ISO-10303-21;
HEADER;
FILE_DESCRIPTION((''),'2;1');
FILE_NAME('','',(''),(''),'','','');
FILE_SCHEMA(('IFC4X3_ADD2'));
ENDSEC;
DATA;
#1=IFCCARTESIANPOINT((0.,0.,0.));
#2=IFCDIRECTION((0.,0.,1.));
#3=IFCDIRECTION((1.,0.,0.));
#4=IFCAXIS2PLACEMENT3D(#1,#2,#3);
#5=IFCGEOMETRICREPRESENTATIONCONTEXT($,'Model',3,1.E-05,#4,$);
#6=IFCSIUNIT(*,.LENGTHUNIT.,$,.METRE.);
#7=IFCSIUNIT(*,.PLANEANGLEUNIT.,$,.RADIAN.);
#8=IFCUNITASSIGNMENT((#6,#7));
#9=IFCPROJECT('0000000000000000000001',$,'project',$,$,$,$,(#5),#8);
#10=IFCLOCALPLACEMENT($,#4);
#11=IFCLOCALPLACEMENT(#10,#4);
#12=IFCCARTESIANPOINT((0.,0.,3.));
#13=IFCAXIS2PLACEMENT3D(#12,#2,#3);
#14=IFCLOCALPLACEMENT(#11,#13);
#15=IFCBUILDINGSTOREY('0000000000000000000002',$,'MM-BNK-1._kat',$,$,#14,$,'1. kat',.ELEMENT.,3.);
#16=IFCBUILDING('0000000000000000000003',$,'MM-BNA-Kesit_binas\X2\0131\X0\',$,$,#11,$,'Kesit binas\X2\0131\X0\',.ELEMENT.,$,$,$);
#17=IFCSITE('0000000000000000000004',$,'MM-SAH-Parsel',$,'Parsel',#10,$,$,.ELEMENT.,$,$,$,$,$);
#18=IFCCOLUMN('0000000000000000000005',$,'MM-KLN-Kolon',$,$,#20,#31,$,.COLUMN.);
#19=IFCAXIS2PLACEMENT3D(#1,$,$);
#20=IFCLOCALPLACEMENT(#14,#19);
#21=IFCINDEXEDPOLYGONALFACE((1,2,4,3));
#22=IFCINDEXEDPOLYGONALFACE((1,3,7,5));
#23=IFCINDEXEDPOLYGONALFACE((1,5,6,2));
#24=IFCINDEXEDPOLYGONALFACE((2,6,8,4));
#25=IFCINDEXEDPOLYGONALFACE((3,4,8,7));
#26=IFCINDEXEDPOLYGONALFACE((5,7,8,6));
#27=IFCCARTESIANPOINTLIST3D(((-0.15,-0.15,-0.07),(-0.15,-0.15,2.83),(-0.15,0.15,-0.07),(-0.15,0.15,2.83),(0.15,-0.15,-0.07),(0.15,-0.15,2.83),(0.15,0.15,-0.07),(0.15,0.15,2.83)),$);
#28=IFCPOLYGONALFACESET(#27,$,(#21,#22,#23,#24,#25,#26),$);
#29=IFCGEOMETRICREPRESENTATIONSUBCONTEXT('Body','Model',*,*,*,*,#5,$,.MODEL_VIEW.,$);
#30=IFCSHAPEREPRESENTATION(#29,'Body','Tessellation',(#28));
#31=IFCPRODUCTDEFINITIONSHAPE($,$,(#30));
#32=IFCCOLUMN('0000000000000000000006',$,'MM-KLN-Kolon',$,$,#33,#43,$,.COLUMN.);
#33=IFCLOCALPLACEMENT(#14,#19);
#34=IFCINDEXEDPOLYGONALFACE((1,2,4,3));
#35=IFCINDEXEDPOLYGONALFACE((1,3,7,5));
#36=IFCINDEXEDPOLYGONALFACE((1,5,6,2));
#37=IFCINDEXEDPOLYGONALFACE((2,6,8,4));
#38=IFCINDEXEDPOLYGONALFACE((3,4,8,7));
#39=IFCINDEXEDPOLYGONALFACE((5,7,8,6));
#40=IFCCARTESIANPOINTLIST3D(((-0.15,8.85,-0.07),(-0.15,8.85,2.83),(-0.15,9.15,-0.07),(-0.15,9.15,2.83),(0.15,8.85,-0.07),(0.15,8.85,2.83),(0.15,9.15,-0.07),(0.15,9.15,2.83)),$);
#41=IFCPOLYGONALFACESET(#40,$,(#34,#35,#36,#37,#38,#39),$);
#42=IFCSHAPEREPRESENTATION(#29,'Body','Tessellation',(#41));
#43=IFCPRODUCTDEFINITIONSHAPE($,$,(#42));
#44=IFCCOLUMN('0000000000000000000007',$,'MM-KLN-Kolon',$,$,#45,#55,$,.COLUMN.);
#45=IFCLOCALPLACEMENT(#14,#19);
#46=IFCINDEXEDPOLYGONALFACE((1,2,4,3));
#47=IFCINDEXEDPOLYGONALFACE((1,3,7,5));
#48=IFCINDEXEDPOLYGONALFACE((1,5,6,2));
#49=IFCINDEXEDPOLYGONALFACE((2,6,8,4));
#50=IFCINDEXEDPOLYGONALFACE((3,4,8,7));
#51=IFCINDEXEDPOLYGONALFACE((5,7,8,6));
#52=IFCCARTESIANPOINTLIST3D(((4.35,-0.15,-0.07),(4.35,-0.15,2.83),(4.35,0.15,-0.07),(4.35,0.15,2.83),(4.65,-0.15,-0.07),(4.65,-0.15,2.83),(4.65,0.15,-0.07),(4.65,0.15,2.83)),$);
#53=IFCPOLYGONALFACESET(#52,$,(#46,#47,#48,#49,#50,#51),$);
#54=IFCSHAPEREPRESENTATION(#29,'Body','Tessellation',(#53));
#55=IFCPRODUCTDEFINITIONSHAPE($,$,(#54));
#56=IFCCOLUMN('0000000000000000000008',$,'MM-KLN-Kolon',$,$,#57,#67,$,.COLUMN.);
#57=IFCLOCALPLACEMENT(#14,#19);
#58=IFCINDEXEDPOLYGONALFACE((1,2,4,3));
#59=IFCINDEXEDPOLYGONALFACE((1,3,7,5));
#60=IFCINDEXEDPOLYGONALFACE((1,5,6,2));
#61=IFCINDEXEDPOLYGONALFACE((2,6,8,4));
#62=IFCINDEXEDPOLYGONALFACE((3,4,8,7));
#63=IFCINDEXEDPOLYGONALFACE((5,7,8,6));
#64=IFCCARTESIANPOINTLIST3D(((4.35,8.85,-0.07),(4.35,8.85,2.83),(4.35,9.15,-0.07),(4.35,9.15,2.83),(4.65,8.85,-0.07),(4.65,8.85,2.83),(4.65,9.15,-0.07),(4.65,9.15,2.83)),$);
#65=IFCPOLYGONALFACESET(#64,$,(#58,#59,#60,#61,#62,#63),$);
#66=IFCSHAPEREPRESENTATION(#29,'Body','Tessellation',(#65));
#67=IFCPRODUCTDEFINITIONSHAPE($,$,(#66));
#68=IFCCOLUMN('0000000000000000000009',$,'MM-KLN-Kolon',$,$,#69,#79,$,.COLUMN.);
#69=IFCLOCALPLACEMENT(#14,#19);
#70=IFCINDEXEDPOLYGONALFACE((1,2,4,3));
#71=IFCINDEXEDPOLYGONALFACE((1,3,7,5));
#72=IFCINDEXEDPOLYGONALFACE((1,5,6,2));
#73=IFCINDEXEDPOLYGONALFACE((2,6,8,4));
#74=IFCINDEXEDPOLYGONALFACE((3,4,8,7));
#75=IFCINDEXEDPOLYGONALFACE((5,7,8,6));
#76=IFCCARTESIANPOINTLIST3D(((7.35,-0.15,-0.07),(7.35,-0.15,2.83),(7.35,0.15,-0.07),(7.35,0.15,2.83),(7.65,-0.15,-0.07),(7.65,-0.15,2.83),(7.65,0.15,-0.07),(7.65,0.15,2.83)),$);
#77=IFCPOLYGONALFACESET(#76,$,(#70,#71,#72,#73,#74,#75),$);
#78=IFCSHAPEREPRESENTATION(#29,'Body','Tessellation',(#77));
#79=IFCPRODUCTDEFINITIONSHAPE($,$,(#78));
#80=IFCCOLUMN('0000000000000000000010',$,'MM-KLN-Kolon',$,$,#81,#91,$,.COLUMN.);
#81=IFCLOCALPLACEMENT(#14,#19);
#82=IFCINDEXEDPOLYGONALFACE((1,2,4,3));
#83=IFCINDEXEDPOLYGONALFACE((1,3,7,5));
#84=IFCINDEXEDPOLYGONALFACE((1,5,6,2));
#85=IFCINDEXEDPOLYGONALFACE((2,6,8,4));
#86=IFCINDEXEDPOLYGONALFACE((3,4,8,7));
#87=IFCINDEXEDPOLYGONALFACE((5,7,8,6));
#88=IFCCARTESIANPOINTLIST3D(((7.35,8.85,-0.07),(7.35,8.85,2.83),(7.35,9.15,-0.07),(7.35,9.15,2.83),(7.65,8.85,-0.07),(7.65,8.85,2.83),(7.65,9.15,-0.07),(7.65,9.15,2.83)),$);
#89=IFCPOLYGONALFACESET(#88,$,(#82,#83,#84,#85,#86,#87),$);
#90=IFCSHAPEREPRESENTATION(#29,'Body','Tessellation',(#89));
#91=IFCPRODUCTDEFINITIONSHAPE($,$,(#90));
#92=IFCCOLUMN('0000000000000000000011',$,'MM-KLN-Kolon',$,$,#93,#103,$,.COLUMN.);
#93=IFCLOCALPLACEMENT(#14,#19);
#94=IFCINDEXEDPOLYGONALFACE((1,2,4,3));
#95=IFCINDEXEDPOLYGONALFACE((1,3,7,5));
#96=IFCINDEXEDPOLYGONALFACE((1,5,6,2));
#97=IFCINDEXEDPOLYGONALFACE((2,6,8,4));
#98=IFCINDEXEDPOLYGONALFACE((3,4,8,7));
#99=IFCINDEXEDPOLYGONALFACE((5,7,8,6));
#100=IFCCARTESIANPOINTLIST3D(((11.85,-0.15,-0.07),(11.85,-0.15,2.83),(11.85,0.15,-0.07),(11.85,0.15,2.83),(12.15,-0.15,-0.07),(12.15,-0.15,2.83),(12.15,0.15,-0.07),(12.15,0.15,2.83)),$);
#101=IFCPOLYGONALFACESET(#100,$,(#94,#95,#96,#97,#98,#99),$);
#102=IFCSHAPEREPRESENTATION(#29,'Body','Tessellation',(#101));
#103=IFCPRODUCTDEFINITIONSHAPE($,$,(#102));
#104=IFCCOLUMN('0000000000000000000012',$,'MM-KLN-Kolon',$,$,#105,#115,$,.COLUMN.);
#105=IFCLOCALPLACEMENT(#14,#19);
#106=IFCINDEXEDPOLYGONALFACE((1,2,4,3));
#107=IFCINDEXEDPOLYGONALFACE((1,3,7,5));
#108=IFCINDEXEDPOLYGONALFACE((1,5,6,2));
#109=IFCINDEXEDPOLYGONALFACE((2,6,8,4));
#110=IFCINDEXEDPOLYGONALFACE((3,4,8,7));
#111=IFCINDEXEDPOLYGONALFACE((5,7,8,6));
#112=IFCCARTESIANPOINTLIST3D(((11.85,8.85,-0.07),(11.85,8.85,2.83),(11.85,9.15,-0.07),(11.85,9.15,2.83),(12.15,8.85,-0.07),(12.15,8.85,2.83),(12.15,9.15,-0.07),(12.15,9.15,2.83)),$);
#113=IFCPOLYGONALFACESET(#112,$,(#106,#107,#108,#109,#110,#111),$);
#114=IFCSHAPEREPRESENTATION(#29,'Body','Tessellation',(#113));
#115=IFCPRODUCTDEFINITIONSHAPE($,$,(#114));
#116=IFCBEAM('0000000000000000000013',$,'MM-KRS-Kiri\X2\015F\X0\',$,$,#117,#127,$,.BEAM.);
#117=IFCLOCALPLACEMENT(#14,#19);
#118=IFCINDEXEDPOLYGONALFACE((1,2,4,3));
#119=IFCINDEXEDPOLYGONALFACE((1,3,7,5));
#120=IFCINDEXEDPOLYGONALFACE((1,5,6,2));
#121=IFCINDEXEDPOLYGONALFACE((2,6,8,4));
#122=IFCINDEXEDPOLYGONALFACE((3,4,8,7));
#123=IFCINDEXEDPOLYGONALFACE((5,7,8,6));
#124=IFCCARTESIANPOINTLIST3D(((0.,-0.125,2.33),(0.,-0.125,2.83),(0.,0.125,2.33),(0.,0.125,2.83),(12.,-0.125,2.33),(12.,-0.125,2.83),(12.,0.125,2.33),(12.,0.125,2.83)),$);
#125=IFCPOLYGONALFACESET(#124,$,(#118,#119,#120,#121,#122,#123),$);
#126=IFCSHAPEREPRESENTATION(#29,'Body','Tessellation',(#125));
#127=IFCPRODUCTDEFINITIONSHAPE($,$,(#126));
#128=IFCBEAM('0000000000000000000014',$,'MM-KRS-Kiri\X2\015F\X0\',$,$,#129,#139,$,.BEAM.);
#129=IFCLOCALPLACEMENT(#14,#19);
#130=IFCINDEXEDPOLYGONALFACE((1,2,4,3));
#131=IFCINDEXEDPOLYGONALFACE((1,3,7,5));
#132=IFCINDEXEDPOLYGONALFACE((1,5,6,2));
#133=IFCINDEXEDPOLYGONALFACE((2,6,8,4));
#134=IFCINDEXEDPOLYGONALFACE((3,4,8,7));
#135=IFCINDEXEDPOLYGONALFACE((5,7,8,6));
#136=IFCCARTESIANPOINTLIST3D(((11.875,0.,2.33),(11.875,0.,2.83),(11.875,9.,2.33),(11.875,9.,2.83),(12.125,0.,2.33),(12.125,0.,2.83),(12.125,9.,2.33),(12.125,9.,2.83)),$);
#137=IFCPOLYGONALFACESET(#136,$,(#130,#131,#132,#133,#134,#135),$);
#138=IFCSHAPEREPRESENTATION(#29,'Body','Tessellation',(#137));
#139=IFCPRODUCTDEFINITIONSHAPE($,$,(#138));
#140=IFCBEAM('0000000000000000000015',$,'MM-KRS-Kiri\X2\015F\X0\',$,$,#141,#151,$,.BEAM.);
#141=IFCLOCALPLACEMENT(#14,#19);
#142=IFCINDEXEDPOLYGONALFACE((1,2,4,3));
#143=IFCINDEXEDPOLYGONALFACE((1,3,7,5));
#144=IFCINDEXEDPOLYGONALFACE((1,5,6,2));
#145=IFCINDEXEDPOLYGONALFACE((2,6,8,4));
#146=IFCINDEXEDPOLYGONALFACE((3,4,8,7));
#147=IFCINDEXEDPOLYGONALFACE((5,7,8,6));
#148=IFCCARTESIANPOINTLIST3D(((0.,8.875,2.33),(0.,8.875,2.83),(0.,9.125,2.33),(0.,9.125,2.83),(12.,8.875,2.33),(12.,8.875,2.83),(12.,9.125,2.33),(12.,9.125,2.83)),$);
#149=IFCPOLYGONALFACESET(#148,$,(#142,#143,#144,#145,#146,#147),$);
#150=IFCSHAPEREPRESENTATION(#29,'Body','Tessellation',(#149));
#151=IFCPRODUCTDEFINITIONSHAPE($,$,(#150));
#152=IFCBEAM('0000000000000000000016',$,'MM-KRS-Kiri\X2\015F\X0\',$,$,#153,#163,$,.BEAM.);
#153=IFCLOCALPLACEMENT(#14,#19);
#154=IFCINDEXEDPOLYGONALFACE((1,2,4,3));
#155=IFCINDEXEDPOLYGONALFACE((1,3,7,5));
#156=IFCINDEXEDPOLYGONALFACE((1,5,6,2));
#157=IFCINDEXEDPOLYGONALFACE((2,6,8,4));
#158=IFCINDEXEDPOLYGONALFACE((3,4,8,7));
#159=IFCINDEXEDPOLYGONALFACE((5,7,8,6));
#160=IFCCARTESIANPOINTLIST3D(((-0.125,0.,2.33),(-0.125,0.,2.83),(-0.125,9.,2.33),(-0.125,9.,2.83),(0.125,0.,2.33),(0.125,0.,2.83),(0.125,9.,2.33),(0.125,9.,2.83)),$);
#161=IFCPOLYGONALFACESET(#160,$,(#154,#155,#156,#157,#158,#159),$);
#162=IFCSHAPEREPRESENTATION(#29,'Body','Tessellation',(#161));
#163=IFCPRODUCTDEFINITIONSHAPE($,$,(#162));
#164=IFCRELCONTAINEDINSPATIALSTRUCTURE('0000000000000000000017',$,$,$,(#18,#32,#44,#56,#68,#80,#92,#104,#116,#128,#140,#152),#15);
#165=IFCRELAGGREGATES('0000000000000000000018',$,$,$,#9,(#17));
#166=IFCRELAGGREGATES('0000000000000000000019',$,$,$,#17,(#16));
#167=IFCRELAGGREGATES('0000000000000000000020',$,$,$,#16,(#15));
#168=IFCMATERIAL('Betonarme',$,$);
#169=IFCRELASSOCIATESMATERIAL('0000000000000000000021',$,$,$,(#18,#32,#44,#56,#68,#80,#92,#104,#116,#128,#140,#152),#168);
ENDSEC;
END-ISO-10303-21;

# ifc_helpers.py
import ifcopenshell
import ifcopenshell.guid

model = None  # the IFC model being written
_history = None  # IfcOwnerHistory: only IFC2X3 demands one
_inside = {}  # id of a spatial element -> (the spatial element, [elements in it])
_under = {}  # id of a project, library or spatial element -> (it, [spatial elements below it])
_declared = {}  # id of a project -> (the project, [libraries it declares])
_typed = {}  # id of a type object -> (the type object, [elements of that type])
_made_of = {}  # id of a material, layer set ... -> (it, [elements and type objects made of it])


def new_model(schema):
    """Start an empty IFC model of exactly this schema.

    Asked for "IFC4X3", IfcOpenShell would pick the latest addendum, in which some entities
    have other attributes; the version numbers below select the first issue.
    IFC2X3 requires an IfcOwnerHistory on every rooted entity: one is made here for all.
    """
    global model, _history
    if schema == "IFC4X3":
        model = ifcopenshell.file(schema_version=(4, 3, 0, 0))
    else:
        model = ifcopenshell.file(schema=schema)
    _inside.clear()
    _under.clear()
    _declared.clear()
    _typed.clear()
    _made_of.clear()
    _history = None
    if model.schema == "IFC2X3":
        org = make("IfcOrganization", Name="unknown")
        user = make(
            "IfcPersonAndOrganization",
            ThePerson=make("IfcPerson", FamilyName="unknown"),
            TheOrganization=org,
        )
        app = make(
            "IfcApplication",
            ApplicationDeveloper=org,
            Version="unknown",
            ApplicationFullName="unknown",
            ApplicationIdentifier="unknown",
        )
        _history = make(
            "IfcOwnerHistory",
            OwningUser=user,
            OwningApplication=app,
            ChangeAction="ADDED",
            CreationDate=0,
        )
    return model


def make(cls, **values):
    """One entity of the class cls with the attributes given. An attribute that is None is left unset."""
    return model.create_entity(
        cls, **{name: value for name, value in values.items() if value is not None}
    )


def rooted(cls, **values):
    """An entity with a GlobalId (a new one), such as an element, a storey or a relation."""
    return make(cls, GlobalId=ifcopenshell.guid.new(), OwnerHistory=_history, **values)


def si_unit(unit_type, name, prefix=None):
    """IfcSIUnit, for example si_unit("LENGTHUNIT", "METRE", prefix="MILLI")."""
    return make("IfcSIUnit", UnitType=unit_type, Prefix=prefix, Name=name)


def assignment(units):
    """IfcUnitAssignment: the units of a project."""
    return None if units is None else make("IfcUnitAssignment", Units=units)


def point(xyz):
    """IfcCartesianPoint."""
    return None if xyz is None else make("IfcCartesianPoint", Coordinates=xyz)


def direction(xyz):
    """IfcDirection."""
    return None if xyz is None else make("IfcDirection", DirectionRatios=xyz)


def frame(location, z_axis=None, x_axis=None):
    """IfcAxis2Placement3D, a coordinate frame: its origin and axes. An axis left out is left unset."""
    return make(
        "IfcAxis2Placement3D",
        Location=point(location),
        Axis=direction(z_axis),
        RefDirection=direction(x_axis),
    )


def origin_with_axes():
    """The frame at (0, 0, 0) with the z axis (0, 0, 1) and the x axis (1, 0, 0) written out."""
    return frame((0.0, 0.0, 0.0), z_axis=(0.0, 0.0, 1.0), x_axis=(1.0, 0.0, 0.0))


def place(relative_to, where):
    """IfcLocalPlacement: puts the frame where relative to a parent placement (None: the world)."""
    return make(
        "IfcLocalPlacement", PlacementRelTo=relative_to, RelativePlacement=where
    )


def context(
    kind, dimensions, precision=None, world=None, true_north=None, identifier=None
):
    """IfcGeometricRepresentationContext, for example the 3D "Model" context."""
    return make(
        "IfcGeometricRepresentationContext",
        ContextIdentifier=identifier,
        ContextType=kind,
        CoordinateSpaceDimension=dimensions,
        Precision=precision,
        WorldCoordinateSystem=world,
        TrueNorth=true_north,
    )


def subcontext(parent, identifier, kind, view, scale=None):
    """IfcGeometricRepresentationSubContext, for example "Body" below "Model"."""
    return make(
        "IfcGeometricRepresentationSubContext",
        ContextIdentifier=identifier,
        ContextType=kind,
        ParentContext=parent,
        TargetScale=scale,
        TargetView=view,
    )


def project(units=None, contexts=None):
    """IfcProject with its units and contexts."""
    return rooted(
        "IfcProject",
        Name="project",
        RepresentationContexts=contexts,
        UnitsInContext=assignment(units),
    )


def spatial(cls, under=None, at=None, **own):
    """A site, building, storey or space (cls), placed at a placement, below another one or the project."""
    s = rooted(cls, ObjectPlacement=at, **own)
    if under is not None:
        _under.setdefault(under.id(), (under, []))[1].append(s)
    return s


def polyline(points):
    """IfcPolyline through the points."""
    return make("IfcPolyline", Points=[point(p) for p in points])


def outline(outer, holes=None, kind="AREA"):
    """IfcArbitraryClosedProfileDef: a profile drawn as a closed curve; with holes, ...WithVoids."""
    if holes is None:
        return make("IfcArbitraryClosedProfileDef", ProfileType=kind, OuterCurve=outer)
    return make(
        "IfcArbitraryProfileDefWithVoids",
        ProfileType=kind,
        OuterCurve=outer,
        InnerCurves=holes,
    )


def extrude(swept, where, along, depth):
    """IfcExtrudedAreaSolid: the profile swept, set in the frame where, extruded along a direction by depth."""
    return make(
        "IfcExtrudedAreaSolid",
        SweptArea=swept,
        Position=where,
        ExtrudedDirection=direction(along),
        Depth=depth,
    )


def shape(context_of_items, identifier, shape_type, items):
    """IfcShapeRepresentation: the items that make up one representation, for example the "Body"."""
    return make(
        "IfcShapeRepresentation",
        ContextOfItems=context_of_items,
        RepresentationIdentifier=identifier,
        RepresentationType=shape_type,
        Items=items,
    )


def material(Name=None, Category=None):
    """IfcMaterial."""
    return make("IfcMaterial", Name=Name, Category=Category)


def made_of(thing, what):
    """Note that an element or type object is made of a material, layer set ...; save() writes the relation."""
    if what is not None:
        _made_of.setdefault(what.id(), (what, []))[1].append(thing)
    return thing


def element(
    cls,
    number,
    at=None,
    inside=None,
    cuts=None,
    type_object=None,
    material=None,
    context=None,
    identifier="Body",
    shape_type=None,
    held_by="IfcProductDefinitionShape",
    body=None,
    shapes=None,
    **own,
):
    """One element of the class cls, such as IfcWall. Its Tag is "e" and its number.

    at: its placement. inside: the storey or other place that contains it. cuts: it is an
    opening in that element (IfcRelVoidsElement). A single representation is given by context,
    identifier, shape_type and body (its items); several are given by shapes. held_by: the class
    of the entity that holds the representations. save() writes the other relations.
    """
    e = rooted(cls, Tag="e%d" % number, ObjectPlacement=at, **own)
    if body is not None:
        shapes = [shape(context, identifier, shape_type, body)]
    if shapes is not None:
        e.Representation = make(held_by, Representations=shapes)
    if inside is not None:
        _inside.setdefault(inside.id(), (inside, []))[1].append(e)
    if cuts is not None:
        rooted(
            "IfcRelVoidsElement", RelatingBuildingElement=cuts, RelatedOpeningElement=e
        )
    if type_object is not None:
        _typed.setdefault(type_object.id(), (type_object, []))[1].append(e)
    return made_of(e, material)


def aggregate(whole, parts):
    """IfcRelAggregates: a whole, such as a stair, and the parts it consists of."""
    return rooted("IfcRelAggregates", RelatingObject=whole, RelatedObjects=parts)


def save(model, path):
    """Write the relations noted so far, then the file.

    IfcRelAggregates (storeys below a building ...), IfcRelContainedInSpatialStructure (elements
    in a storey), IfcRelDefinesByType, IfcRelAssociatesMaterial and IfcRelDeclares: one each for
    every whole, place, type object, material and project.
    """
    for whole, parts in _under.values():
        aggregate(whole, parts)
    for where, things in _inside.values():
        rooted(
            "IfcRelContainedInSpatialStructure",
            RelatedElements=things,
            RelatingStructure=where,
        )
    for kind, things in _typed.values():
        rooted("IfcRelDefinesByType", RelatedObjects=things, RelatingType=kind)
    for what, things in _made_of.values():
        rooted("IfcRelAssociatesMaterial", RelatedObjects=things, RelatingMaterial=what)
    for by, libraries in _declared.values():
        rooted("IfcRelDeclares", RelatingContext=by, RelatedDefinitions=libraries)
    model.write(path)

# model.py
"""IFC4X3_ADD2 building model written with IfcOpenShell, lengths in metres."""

from ifc_helpers import new_model, si_unit, frame, origin_with_axes, place, context, subcontext, project, spatial, polyline, outline, extrude, material, element, save


model = new_model("IFC4X3_ADD2")

# Units and contexts
model_context = context("Model", 3, precision=1e-05, world=origin_with_axes())
body_context = subcontext(model_context, "Body", "Model", "MODEL_VIEW")
ifc_project = project(units=[si_unit("LENGTHUNIT", "METRE"), si_unit("PLANEANGLEUNIT", "RADIAN")], contexts=[model_context])

# Site, building, storey
site_placement = place(None, origin_with_axes())
site = spatial("IfcSite", under=ifc_project, at=site_placement, Name="MM-SAH-Parsel", ObjectType="Parsel", CompositionType="ELEMENT")
building_placement = place(site_placement, origin_with_axes())
building = spatial("IfcBuilding", under=site, at=building_placement, Name="MM-BNA-Kesit_binası", LongName="Kesit binası", CompositionType="ELEMENT")
storey_placement = place(building_placement, frame((0.0, 0.0, 3.0), z_axis=(0.0, 0.0, 1.0), x_axis=(1.0, 0.0, 0.0)))
storey = spatial("IfcBuildingStorey", under=building, at=storey_placement, Name="MM-BNK-1._kat", LongName="1. kat", CompositionType="ELEMENT", Elevation=3.0)

# Columns
ifc_material_1 = material(Name="Betonarme")
column_1_placement = place(storey_placement, origin_with_axes())
element("IfcColumn", 1, at=column_1_placement, inside=storey, material=ifc_material_1, Name="MM-KLN-Kolon", PredefinedType="COLUMN", context=body_context, shape_type="SweptSolid", body=[
    extrude(outline(polyline([(-0.15, -0.15), (0.15, -0.15), (0.15, 0.15), (-0.15, 0.15), (-0.15, -0.15)])), frame((0.0, 0.0, -0.07)), (0.0, 0.0, 1.0), 2.9),
])
column_2_placement = place(storey_placement, origin_with_axes())
element("IfcColumn", 2, at=column_2_placement, inside=storey, material=ifc_material_1, Name="MM-KLN-Kolon", PredefinedType="COLUMN", context=body_context, shape_type="SweptSolid", body=[
    extrude(outline(polyline([(-0.15, 8.85), (0.15, 8.85), (0.15, 9.15), (-0.15, 9.15), (-0.15, 8.85)])), frame((0.0, 0.0, -0.07)), (0.0, 0.0, 1.0), 2.9),
])
column_3_placement = place(storey_placement, origin_with_axes())
element("IfcColumn", 3, at=column_3_placement, inside=storey, material=ifc_material_1, Name="MM-KLN-Kolon", PredefinedType="COLUMN", context=body_context, shape_type="SweptSolid", body=[
    extrude(outline(polyline([(4.35, -0.15), (4.65, -0.15), (4.65, 0.15), (4.35, 0.15), (4.35, -0.15)])), frame((0.0, 0.0, -0.07)), (0.0, 0.0, 1.0), 2.9),
])
column_4_placement = place(storey_placement, origin_with_axes())
element("IfcColumn", 4, at=column_4_placement, inside=storey, material=ifc_material_1, Name="MM-KLN-Kolon", PredefinedType="COLUMN", context=body_context, shape_type="SweptSolid", body=[
    extrude(outline(polyline([(4.35, 8.85), (4.65, 8.85), (4.65, 9.15), (4.35, 9.15), (4.35, 8.85)])), frame((0.0, 0.0, -0.07)), (0.0, 0.0, 1.0), 2.9),
])
column_5_placement = place(storey_placement, origin_with_axes())
element("IfcColumn", 5, at=column_5_placement, inside=storey, material=ifc_material_1, Name="MM-KLN-Kolon", PredefinedType="COLUMN", context=body_context, shape_type="SweptSolid", body=[
    extrude(outline(polyline([(7.35, -0.15), (7.65, -0.15), (7.65, 0.15), (7.35, 0.15), (7.35, -0.15)])), frame((0.0, 0.0, -0.07)), (0.0, 0.0, 1.0), 2.9),
])
column_6_placement = place(storey_placement, origin_with_axes())
element("IfcColumn", 6, at=column_6_placement, inside=storey, material=ifc_material_1, Name="MM-KLN-Kolon", PredefinedType="COLUMN", context=body_context, shape_type="SweptSolid", body=[
    extrude(outline(polyline([(7.35, 8.85), (7.65, 8.85), (7.65, 9.15), (7.35, 9.15), (7.35, 8.85)])), frame((0.0, 0.0, -0.07)), (0.0, 0.0, 1.0), 2.9),
])
column_7_placement = place(storey_placement, origin_with_axes())
element("IfcColumn", 7, at=column_7_placement, inside=storey, material=ifc_material_1, Name="MM-KLN-Kolon", PredefinedType="COLUMN", context=body_context, shape_type="SweptSolid", body=[
    extrude(outline(polyline([(11.85, -0.15), (12.15, -0.15), (12.15, 0.15), (11.85, 0.15), (11.85, -0.15)])), frame((0.0, 0.0, -0.07)), (0.0, 0.0, 1.0), 2.9),
])
column_8_placement = place(storey_placement, origin_with_axes())
element("IfcColumn", 8, at=column_8_placement, inside=storey, material=ifc_material_1, Name="MM-KLN-Kolon", PredefinedType="COLUMN", context=body_context, shape_type="SweptSolid", body=[
    extrude(outline(polyline([(11.85, 8.85), (12.15, 8.85), (12.15, 9.15), (11.85, 9.15), (11.85, 8.85)])), frame((0.0, 0.0, -0.07)), (0.0, 0.0, 1.0), 2.9),
])

# Beams
beam_1_placement = place(storey_placement, origin_with_axes())
element("IfcBeam", 9, at=beam_1_placement, inside=storey, material=ifc_material_1, Name="MM-KRS-Kiriş", PredefinedType="BEAM", context=body_context, shape_type="SweptSolid", body=[
    extrude(outline(polyline([(0.0, 0.125), (12.0, 0.125), (12.0, -0.125), (0.0, -0.125), (0.0, 0.125)])), frame((0.0, 0.0, 2.33)), (0.0, 0.0, 1.0), 0.5),
])
beam_2_placement = place(storey_placement, origin_with_axes())
element("IfcBeam", 10, at=beam_2_placement, inside=storey, material=ifc_material_1, Name="MM-KRS-Kiriş", PredefinedType="BEAM", context=body_context, shape_type="SweptSolid", body=[
    extrude(outline(polyline([(11.875, 0.0), (11.875, 9.0), (12.125, 9.0), (12.125, 0.0), (11.875, 0.0)])), frame((0.0, 0.0, 2.33)), (0.0, 0.0, 1.0), 0.5),
])
beam_3_placement = place(storey_placement, origin_with_axes())
element("IfcBeam", 11, at=beam_3_placement, inside=storey, material=ifc_material_1, Name="MM-KRS-Kiriş", PredefinedType="BEAM", context=body_context, shape_type="SweptSolid", body=[
    extrude(outline(polyline([(12.0, 8.875), (0.0, 8.875), (0.0, 9.125), (12.0, 9.125), (12.0, 8.875)])), frame((0.0, 0.0, 2.33)), (0.0, 0.0, 1.0), 0.5),
])
beam_4_placement = place(storey_placement, origin_with_axes())
element("IfcBeam", 12, at=beam_4_placement, inside=storey, material=ifc_material_1, Name="MM-KRS-Kiriş", PredefinedType="BEAM", context=body_context, shape_type="SweptSolid", body=[
    extrude(outline(polyline([(0.125, 9.0), (0.125, 0.0), (-0.125, 0.0), (-0.125, 9.0), (0.125, 9.0)])), frame((0.0, 0.0, 2.33)), (0.0, 0.0, 1.0), 0.5),
])

save(model, "model.ifc")
